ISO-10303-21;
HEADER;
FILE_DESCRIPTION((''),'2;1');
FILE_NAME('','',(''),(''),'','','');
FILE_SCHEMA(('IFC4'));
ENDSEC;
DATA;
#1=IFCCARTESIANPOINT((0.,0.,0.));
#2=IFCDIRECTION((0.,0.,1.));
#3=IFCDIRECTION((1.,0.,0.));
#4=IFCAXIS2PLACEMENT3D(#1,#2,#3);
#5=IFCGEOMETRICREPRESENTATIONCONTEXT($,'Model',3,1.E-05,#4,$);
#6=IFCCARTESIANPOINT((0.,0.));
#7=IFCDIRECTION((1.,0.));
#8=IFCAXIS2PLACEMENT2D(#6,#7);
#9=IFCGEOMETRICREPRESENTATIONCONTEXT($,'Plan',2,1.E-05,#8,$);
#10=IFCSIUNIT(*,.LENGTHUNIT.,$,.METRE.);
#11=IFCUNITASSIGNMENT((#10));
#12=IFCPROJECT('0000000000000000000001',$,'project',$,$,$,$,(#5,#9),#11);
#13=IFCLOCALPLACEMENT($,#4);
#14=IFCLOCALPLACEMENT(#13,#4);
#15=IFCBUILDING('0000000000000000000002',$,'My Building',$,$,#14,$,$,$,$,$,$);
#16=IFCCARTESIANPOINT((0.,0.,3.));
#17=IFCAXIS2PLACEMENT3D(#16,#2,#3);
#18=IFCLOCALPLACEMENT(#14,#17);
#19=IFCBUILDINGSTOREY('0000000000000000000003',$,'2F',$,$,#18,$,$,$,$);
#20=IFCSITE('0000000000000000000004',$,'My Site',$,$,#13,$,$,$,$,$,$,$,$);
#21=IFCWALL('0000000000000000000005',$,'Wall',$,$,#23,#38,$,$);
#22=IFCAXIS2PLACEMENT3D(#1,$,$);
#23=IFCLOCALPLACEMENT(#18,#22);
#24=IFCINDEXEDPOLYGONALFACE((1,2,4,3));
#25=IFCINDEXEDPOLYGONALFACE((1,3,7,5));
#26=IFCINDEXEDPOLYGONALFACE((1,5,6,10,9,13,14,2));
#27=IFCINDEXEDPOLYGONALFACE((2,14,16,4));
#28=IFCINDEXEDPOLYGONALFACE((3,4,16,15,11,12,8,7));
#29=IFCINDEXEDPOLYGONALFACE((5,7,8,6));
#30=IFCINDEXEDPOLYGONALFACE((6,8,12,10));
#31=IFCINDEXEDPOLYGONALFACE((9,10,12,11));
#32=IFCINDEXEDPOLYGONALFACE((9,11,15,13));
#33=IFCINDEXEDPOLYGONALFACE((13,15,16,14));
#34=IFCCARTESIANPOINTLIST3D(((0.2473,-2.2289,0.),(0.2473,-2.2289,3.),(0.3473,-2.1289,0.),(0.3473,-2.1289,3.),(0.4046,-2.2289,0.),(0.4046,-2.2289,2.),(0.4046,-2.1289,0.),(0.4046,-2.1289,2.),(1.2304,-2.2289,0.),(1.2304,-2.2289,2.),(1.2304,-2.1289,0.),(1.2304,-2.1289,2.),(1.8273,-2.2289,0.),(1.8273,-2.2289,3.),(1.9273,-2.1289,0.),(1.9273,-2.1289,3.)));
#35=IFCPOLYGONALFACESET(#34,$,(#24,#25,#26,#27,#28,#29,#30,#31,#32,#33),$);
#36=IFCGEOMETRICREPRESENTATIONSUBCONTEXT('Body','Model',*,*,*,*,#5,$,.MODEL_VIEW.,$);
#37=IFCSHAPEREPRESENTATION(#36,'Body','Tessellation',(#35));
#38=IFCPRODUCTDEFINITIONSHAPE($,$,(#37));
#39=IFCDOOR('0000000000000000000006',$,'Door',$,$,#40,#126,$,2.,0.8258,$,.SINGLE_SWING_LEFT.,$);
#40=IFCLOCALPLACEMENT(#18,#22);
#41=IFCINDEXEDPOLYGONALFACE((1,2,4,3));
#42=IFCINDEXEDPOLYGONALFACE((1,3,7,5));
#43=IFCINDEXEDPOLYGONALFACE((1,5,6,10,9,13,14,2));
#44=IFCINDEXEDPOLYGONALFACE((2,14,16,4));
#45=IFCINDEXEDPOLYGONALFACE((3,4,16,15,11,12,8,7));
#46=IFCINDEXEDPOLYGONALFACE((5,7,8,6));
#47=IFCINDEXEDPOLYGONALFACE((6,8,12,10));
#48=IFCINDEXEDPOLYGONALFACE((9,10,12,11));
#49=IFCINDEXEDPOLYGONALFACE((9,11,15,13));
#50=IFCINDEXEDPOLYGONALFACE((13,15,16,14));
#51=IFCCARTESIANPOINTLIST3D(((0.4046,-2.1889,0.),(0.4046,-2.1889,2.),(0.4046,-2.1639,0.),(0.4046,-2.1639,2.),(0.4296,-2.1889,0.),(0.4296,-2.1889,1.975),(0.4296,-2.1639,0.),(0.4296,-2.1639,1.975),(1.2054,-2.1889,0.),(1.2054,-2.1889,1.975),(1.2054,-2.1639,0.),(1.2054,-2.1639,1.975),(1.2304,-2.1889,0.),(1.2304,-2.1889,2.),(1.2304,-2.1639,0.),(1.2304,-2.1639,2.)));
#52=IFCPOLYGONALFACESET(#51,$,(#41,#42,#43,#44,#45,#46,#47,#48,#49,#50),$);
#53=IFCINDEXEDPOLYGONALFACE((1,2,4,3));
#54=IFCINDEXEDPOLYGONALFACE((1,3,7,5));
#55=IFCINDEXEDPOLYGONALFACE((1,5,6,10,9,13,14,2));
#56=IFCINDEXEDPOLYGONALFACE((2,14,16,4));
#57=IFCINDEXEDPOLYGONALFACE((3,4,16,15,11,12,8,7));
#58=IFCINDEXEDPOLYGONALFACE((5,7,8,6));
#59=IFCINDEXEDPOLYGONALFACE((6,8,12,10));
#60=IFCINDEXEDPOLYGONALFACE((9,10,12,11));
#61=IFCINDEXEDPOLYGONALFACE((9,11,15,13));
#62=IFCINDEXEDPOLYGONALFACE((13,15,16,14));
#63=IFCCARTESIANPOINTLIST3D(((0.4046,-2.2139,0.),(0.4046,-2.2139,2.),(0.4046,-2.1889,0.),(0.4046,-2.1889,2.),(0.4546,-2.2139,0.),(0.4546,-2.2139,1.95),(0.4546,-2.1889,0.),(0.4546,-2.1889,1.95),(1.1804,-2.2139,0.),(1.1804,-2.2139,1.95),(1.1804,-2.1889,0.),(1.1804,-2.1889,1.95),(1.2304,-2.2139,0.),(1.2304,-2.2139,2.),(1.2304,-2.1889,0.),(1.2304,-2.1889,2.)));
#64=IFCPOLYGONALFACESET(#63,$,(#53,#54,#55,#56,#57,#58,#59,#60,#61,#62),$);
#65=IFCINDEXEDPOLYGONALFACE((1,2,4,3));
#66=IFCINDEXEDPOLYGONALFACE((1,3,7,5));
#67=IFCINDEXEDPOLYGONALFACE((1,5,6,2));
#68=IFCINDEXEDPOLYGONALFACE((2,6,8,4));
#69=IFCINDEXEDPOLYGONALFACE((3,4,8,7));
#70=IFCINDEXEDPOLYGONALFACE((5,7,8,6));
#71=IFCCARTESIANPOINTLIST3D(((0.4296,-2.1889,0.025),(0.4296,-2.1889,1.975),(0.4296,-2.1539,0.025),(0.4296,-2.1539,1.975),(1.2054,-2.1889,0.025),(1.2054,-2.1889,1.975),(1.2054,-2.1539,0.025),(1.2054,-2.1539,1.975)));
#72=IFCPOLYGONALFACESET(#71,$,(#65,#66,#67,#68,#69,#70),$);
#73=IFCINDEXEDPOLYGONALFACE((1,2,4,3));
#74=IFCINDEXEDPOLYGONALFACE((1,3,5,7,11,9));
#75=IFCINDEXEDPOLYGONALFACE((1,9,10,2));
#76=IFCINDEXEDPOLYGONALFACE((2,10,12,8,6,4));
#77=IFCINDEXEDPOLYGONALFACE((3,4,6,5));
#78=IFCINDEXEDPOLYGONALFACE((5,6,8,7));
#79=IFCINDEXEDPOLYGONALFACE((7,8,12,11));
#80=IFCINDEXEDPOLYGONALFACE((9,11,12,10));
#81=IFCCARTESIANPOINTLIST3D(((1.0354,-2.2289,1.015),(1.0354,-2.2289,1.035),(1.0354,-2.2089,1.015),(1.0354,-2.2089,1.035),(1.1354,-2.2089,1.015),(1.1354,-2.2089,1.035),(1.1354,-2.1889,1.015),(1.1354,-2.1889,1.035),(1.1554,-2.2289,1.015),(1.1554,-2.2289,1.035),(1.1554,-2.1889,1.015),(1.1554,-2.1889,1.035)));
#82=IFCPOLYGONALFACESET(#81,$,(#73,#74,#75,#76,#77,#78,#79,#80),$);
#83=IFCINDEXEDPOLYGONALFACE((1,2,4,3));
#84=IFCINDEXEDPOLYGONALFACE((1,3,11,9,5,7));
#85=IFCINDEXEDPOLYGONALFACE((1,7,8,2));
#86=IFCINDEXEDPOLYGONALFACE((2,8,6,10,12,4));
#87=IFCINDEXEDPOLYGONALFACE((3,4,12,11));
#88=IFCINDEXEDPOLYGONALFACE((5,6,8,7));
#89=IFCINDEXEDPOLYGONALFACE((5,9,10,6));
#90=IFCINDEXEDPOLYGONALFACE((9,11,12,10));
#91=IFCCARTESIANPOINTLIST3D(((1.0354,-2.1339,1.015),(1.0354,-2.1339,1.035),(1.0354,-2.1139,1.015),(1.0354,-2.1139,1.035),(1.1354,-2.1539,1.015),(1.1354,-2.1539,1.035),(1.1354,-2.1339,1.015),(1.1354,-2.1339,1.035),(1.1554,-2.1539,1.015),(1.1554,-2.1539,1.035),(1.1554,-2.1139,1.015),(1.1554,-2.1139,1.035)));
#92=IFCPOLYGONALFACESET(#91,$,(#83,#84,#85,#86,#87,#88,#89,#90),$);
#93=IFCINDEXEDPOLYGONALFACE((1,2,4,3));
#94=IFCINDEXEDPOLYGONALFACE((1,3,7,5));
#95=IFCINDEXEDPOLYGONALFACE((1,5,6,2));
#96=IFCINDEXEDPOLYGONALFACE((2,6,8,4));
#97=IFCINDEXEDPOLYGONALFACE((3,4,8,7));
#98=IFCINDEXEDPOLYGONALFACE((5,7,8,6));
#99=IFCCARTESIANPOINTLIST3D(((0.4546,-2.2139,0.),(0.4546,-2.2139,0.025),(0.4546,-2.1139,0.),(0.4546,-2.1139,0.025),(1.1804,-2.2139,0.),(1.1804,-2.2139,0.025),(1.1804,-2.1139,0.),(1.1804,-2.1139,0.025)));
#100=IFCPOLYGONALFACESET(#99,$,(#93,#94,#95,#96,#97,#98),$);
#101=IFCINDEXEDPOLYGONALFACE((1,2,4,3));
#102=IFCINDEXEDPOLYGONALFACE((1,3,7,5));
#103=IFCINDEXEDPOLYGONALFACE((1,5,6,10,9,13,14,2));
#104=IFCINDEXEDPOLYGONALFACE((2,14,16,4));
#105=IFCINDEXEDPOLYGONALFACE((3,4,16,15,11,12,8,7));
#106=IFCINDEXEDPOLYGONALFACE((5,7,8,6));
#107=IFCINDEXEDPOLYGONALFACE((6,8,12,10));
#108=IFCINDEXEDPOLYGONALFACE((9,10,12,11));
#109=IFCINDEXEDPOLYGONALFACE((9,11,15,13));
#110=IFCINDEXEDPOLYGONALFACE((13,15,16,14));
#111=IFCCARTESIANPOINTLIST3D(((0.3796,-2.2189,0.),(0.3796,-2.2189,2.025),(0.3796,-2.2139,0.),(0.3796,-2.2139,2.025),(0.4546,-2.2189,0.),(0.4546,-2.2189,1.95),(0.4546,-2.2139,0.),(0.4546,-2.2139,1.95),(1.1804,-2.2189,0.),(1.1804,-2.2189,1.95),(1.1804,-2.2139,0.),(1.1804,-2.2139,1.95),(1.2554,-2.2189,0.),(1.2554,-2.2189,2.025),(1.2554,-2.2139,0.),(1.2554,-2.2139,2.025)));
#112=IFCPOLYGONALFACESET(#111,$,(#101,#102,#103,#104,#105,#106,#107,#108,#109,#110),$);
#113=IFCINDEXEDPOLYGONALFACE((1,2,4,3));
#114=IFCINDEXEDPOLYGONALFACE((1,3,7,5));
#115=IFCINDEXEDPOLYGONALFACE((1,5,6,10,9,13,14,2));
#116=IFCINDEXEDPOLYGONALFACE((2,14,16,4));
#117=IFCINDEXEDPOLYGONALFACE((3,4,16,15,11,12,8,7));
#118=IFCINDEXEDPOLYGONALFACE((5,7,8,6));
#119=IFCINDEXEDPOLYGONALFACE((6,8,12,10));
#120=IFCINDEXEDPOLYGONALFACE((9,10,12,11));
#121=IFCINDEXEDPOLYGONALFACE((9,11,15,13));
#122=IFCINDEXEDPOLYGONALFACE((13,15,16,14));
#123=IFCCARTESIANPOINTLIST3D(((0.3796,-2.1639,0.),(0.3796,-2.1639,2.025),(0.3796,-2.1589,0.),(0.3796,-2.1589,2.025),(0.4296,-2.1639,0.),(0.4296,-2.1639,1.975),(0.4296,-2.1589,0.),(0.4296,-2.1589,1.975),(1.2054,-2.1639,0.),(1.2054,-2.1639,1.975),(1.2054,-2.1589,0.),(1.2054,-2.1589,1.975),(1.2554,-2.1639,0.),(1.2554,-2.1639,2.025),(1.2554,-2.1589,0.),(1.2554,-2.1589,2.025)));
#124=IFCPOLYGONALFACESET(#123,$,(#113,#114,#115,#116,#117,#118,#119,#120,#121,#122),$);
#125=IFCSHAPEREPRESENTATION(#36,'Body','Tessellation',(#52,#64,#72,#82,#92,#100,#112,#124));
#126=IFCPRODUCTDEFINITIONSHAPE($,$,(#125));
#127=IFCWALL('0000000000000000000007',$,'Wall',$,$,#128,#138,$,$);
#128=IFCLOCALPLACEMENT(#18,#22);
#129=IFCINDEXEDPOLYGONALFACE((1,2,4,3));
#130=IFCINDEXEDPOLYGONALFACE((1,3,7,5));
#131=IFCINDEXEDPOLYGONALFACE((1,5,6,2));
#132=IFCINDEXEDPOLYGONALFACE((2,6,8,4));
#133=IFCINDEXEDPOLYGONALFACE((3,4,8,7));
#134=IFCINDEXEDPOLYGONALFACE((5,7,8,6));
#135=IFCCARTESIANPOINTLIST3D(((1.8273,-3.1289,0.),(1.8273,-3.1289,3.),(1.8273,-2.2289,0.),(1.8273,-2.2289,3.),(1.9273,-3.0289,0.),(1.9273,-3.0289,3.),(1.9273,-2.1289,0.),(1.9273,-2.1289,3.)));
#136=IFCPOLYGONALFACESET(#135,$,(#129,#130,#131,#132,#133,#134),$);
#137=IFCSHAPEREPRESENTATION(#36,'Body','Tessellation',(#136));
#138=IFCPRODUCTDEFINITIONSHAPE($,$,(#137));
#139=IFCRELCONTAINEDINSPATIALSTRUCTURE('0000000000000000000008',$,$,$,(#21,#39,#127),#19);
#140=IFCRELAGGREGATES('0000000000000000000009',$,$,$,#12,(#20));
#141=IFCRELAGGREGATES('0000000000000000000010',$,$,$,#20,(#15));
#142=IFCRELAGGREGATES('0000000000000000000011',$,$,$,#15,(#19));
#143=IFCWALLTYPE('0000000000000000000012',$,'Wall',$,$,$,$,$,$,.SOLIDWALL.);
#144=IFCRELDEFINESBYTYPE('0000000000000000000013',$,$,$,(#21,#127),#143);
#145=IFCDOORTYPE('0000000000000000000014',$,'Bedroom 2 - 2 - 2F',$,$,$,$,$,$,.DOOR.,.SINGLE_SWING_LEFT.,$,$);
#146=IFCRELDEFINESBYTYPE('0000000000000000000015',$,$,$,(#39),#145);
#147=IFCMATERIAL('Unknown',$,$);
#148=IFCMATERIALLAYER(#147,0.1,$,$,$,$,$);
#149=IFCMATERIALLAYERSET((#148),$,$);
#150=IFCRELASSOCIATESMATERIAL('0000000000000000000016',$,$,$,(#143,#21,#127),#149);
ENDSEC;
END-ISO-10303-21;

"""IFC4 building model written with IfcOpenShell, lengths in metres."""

from ifc_helpers import new_model, entity, si_unit, frame, origin_with_axes, origin_2d_with_axis, place, context, subcontext, project, spatial, line, indexed_curve, outline, extrude, shape, source, transform, mapped, material, layer, layer_set, layer_usage, type_object, type_shapes, element, fill, save


model = new_model("IFC4")

# Units and contexts
model_context = context("Model", 3, precision=1e-05, world=origin_with_axes())
plan_context = context("Plan", 2, precision=1e-05, world=origin_2d_with_axis())
body_context_1 = subcontext(model_context, "Body", "Model", "MODEL_VIEW")
body_context_2 = subcontext(plan_context, "Body", "Plan", "PLAN_VIEW")
ifc_project = project(units=[si_unit("LENGTHUNIT", "METRE")], contexts=[model_context, plan_context])

# Site, building, storey
site_placement = place(None, origin_with_axes())
site = spatial("IfcSite", under=ifc_project, at=site_placement, Name="My Site")
building_placement = place(site_placement, origin_with_axes())
building = spatial("IfcBuilding", under=site, at=building_placement, Name="My Building")
storey_placement = place(building_placement, frame((0.0, 0.0, 3.0), z_axis=(0.0, 0.0, 1.0), x_axis=(1.0, 0.0, 0.0)))
storey = spatial("IfcBuildingStorey", under=building, at=storey_placement, Name="2F")

# Shared definitions
ifc_material = material(Name="Unknown")

# Shared definitions
ifc_layer = layer(ifc_material, 0.1)
ifc_layer_set = layer_set([ifc_layer])
wall_type = type_object("IfcWallType", Name="Wall", PredefinedType="SOLIDWALL", material=ifc_layer_set)

# Wall, opening, door
ifc_layer_usage_1 = layer_usage(ifc_layer_set, "AXIS2", "POSITIVE", 0.0)
wall_1_placement = place(storey_placement, frame((0.2473, -2.2289, 0.0), z_axis=(0.0, 0.0, 1.0), x_axis=(1.0, 0.0, 0.0)))
wall_1 = element("IfcWall", 1, at=wall_1_placement, inside=storey, type_object=wall_type, material=ifc_layer_usage_1, Name="Wall", context=body_context_1, shape_type="SweptSolid", body=[
    extrude(outline(indexed_curve([(0.0, 0.0), (0.1, 0.1), (1.68, 0.1), (1.58, 0.0)], segments=[line(1, 2, 3, 4, 1)])), origin_with_axes(), (0.0, 0.0, 1.0), 3.0),
])
shared_shape_1 = source(origin_with_axes(), body_context_1, "Body", "SweptSolid", [
    extrude(outline(indexed_curve([(0.0, 0.0), (0.8258, 0.0), (0.8258, 2.0), (0.0, 2.0)], segments=[line(1, 2, 3, 4, 1)])), frame((0.0, -0.6, 0.0), z_axis=(0.0, -1.0, 0.0), x_axis=(1.0, 0.0, 0.0)), (0.0, 0.0, -1.0), 1.2),
])
opening_1_placement = place(wall_1_placement, frame((0.1573, 0.015, 0.0), z_axis=(0.0, 0.0, 1.0), x_axis=(1.0, 0.0, 0.0)))
opening_1 = element("IfcOpeningElement", 2, at=opening_1_placement, cuts=wall_1, PredefinedType="OPENING", context=body_context_1, shape_type="MappedRepresentation", body=[
    mapped(shared_shape_1, transform((0.0, 0.0, 0.0), x_axis=(1.0, 0.0, 0.0), y_axis=(0.0, 1.0, 0.0), z_axis=(0.0, 0.0, 1.0), scale=1.0)),
])
door_type_1 = type_object("IfcDoorType", Name="Bedroom 2 - 2 - 2F", OperationType="SINGLE_SWING_LEFT", PredefinedType="DOOR")
shared_shape_2 = source(origin_with_axes(), body_context_1, "Body", "SweptSolid", [
    extrude(outline(indexed_curve([(0.0, 0.0), (0.0, 2.0), (0.8258, 2.0), (0.8258, 0.0), (0.8008, 0.0), (0.8008, 1.975), (0.025, 1.975), (0.025, 0.0)], segments=[line(1, 2, 3, 4, 5, 6, 7, 8, 1)])), frame((0.0, 0.025, 0.0), z_axis=(0.0, -1.0, 0.0), x_axis=(1.0, 0.0, 0.0)), (0.0, 0.0, -1.0), 0.025),
    extrude(outline(indexed_curve([(0.0, 0.0), (0.0, 2.0), (0.8258, 2.0), (0.8258, 0.0), (0.7758, 0.0), (0.7758, 1.95), (0.05, 1.95), (0.05, 0.0)], segments=[line(1, 2, 3, 4, 5, 6, 7, 8, 1)])), frame((0.0, 0.0, 0.0), z_axis=(0.0, -1.0, 0.0), x_axis=(1.0, 0.0, 0.0)), (0.0, 0.0, -1.0), 0.025),
    extrude(outline(indexed_curve([(0.0, 0.0), (0.7758, 0.0), (0.7758, 0.035), (0.0, 0.035)], segments=[line(1, 2, 3, 4, 1)])), frame((0.025, 0.025, 0.025), z_axis=(0.0, 0.0, 1.0), x_axis=(1.0, 0.0, 0.0)), (0.0, 0.0, 1.0), 1.95),
    extrude(outline(indexed_curve([(0.0, 0.0), (0.0, -0.04), (-0.12, -0.04), (-0.12, -0.02), (-0.02, -0.02), (-0.02, 0.0)], segments=[line(1, 2, 3, 4, 5, 6, 1)])), frame((0.7508, 0.025, 1.015), z_axis=(0.0, 0.0, 1.0), x_axis=(1.0, 0.0, 0.0)), (0.0, 0.0, 1.0), 0.02),
    extrude(outline(indexed_curve([(0.0, 0.0), (0.0, 0.04), (-0.12, 0.04), (-0.12, 0.02), (-0.02, 0.02), (-0.02, 0.0)], segments=[line(1, 2, 3, 4, 5, 6, 1)])), frame((0.7508, 0.06, 1.015), z_axis=(0.0, 0.0, 1.0), x_axis=(1.0, 0.0, 0.0)), (0.0, 0.0, 1.0), 0.02),
    extrude(outline(indexed_curve([(0.0, 0.0), (0.7258, 0.0), (0.7258, 0.1), (0.0, 0.1)], segments=[line(1, 2, 3, 4, 1)])), frame((0.05, 0.0, 0.0), z_axis=(0.0, 0.0, 1.0), x_axis=(1.0, 0.0, 0.0)), (0.0, 0.0, 1.0), 0.025),
    extrude(outline(indexed_curve([(0.0, 0.0), (0.0, 2.025), (0.8758, 2.025), (0.8758, 0.0), (0.8008, 0.0), (0.8008, 1.95), (0.075, 1.95), (0.075, 0.0)], segments=[line(1, 2, 3, 4, 5, 6, 7, 8, 1)])), frame((-0.025, -0.005, 0.0), z_axis=(0.0, -1.0, 0.0), x_axis=(1.0, 0.0, 0.0)), (0.0, 0.0, -1.0), 0.005),
    extrude(outline(indexed_curve([(0.0, 0.0), (0.0, 2.025), (0.8758, 2.025), (0.8758, 0.0), (0.8258, 0.0), (0.8258, 1.975), (0.05, 1.975), (0.05, 0.0)], segments=[line(1, 2, 3, 4, 5, 6, 7, 8, 1)])), frame((-0.025, 0.05, 0.0), z_axis=(0.0, -1.0, 0.0), x_axis=(1.0, 0.0, 0.0)), (0.0, 0.0, -1.0), 0.005),
])
shared_shape_3 = source(origin_with_axes(), body_context_2, "Body", "Curve2D", [
    entity("IfcIndexedPolyCurve", entity("IfcCartesianPointList2D", [[0.0, 0.0], [0.0, 0.05], [0.025, 0.05], [0.025, 0.025], [0.05, 0.025], [0.05, 0.0]]), [entity("IfcLineIndex", [1, 2, 3, 4, 5, 6, 1])]),
    entity("IfcIndexedPolyCurve", entity("IfcCartesianPointList2D", [[0.8258, 0.0], [0.8258, 0.05], [0.8008, 0.05], [0.8008, 0.025], [0.7758, 0.025], [0.7758, 0.0]]), [entity("IfcLineIndex", [1, 2, 3, 4, 5, 6, 1])]),
    entity("IfcTrimmedCurve", entity("IfcEllipse", entity("IfcAxis2Placement2D", entity("IfcCartesianPoint", [0.06, 0.05]), entity("IfcDirection", [1.0, 0.0])), 0.7408, 0.7758), [entity("IfcCartesianPoint", [0.8008, 0.05])], [entity("IfcCartesianPoint", [0.06, 0.8258])], True, "CARTESIAN"),
    entity("IfcIndexedPolyCurve", entity("IfcCartesianPointList2D", [[0.025, 0.05], [0.06, 0.05], [0.06, 0.8258], [0.025, 0.8258]]), [entity("IfcLineIndex", [1, 2, 3, 4, 1])]),
])
type_shapes(door_type_1, [shared_shape_2, shared_shape_3])
door_1_placement = place(opening_1_placement, frame((0.0, 0.0, 0.0), z_axis=(0.0, 0.0, 1.0), x_axis=(1.0, 0.0, 0.0)))
door_1 = element("IfcDoor", 3, at=door_1_placement, inside=storey, type_object=door_type_1, Name="Door", OperationType="SINGLE_SWING_LEFT", OverallHeight=2.0, OverallWidth=0.8258, shapes=[
    shape(body_context_1, "Body", "MappedRepresentation", [mapped(shared_shape_2, transform((0.0, 0.0, 0.0), x_axis=(1.0, 0.0, 0.0), y_axis=(0.0, 1.0, 0.0), z_axis=(0.0, 0.0, 1.0), scale=1.0))]),
    shape(body_context_2, "Body", "MappedRepresentation", [mapped(shared_shape_3, transform((0.0, 0.0, 0.0), x_axis=(1.0, 0.0, 0.0), y_axis=(0.0, 1.0, 0.0), z_axis=(0.0, 0.0, 1.0), scale=1.0))]),
])
fill(opening_1, door_1)

# Wall
ifc_layer_usage_2 = layer_usage(ifc_layer_set, "AXIS2", "POSITIVE", 0.0)
wall_2_placement = place(storey_placement, frame((1.8273, -2.2289, 0.0), z_axis=(0.0, 0.0, 1.0), x_axis=(0.0, -1.0, 0.0)))
element("IfcWall", 4, at=wall_2_placement, inside=storey, type_object=wall_type, material=ifc_layer_usage_2, Name="Wall", context=body_context_1, shape_type="SweptSolid", body=[
    extrude(outline(indexed_curve([(0.0, 0.0), (-0.1, 0.1), (0.8, 0.1), (0.9, 0.0)], segments=[line(1, 2, 3, 4, 1)])), origin_with_axes(), (0.0, 0.0, 1.0), 3.0),
])

save(model, "model.ifc")
